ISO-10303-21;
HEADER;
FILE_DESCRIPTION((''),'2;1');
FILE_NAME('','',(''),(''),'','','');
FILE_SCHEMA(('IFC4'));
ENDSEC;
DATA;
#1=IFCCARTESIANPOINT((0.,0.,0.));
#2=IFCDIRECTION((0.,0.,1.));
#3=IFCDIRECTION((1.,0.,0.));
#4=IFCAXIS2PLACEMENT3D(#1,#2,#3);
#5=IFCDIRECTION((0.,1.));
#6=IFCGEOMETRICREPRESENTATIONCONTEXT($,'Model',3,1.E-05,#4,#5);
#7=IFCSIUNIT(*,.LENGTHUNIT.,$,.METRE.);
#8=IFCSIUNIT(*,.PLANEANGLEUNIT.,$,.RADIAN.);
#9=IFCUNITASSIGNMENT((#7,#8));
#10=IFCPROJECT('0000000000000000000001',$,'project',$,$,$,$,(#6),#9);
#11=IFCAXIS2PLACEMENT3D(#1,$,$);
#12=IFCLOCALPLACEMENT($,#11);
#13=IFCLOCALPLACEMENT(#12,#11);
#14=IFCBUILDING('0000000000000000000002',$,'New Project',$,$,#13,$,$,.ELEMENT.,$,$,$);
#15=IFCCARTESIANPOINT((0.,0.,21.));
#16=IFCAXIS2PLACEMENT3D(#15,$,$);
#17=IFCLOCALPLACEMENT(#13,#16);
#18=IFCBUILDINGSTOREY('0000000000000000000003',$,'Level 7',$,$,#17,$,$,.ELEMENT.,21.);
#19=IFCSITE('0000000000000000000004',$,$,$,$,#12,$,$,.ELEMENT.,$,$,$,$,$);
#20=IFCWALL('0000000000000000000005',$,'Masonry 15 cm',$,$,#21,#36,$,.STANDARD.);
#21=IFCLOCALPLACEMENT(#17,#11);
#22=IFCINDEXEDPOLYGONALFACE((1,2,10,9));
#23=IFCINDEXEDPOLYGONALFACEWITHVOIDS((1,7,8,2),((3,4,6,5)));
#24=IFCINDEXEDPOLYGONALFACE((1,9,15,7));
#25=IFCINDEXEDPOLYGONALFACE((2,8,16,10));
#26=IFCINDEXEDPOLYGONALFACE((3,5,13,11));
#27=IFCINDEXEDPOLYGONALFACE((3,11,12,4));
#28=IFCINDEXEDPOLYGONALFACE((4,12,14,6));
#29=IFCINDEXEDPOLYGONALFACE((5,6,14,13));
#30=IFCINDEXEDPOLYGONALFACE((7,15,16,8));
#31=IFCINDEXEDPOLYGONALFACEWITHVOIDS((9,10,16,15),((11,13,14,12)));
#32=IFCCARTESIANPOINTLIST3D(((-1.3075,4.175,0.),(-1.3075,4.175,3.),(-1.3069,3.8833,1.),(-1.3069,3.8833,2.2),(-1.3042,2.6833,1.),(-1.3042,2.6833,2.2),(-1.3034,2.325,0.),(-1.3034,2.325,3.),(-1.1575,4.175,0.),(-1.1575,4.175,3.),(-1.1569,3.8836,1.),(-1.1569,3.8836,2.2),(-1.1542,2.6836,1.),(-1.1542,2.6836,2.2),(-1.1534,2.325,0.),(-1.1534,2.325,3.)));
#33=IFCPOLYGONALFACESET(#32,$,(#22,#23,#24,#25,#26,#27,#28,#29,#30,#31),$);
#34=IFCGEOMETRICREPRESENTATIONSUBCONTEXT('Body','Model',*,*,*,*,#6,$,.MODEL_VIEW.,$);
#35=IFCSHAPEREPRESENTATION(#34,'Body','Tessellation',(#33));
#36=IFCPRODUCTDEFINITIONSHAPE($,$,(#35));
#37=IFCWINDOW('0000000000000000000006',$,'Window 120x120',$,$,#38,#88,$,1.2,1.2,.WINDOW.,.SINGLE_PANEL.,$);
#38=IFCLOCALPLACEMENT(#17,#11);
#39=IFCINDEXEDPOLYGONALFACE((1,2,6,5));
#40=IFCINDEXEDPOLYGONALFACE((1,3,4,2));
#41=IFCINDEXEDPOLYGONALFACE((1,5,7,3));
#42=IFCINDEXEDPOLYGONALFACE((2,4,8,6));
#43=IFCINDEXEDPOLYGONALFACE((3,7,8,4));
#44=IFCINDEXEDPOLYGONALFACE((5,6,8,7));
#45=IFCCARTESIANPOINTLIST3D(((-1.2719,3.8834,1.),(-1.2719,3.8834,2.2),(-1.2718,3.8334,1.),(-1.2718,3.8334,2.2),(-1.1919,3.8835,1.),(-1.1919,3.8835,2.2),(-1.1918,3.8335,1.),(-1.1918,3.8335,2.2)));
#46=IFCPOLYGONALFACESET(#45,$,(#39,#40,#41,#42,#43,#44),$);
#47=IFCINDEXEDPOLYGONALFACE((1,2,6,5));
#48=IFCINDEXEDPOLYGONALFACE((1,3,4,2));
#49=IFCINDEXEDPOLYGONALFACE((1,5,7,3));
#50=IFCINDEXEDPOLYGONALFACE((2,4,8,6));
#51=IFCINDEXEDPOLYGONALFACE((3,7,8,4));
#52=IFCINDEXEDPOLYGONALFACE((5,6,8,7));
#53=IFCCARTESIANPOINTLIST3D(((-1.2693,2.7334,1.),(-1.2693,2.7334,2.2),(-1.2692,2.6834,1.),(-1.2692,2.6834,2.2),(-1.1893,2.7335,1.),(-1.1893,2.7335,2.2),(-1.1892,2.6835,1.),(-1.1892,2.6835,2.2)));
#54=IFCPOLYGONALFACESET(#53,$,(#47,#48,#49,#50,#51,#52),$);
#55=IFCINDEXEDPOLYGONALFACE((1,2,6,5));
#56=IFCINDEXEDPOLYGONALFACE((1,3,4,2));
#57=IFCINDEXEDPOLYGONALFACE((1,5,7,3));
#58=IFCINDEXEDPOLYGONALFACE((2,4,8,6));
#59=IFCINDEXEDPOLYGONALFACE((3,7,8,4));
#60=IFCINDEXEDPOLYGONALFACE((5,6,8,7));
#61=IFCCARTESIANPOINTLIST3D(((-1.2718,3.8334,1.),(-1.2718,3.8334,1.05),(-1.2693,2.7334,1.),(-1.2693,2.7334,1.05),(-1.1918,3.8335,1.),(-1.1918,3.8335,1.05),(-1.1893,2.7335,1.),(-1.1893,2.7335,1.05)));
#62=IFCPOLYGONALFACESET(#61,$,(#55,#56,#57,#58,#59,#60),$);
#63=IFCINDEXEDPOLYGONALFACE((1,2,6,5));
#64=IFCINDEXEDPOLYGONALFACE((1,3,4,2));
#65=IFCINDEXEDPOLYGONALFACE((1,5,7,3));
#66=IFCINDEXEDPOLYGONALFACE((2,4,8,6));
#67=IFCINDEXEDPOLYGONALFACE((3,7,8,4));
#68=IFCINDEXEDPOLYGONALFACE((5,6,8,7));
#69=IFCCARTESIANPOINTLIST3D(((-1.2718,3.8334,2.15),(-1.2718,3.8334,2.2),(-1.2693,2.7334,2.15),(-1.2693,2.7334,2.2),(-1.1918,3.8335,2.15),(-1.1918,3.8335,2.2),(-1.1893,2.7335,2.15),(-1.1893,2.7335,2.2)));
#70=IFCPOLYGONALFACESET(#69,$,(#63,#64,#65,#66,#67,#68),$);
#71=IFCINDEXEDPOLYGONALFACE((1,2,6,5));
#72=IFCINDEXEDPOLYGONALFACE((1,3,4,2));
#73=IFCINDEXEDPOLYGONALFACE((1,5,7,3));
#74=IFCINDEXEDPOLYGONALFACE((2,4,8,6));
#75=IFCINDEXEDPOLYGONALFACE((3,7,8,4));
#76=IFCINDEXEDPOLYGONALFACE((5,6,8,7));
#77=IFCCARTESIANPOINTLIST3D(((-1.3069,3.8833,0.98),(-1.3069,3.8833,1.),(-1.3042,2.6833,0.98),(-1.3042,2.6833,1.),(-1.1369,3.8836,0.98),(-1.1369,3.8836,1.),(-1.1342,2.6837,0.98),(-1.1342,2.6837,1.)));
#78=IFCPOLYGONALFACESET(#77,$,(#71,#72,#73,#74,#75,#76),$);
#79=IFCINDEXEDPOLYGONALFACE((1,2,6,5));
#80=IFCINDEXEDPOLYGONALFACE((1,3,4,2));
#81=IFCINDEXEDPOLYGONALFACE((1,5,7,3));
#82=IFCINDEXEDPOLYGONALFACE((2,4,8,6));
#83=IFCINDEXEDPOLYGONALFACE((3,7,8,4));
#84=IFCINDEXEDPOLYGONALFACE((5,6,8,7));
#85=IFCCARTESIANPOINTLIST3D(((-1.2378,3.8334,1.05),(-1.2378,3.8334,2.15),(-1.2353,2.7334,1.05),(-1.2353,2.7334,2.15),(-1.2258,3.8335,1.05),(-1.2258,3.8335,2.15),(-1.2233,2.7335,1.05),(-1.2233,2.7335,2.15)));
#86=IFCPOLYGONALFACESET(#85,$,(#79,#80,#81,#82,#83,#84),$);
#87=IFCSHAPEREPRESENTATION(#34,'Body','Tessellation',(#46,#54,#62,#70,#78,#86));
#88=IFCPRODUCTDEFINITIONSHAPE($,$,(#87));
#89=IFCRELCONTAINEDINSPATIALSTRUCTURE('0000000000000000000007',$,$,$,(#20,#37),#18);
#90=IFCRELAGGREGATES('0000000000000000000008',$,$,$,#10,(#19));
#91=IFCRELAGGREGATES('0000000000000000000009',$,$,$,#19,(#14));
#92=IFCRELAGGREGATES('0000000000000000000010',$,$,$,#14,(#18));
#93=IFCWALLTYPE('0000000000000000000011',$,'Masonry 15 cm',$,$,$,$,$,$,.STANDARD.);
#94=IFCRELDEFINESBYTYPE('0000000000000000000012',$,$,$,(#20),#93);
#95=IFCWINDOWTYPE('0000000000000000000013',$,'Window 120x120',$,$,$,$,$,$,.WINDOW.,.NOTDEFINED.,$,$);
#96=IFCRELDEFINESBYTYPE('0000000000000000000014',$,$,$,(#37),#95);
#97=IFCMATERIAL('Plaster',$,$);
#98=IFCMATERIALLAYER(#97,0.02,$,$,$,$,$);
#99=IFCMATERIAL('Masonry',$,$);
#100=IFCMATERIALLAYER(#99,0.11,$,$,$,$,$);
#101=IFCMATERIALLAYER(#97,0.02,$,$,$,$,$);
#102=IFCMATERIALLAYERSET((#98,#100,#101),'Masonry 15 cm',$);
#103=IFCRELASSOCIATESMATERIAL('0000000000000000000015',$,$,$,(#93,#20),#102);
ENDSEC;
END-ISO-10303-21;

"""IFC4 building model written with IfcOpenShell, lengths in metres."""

from ifc_helpers import new_model, si_unit, direction, frame, frame_2d, origin, origin_with_axes, place, context, subcontext, project, spatial, polyline, rectangle, outline, extrude, material, layer, layer_set, layer_usage, type_object, element, fill, save


model = new_model("IFC4")

# Units and contexts
model_context = context("Model", 3, precision=1e-05, world=origin_with_axes(), true_north=direction((0.0, 1.0)))
body_context = subcontext(model_context, "Body", "Model", "MODEL_VIEW")
ifc_project = project(units=[si_unit("LENGTHUNIT", "METRE"), si_unit("PLANEANGLEUNIT", "RADIAN")], contexts=[model_context])

# Site, building, storey
site_placement = place(None, origin())
site = spatial("IfcSite", under=ifc_project, at=site_placement, CompositionType="ELEMENT")
building_placement = place(site_placement, origin())
building = spatial("IfcBuilding", under=site, at=building_placement, Name="New Project", CompositionType="ELEMENT")
storey_placement = place(building_placement, frame((0.0, 0.0, 21.0)))
storey = spatial("IfcBuildingStorey", under=building, at=storey_placement, Name="Level 7", CompositionType="ELEMENT", Elevation=21.0)

# Shared definitions
ifc_material_1 = material(Name="Plaster")
ifc_layer_1 = layer(ifc_material_1, 0.02)
ifc_material_2 = material(Name="Masonry")
ifc_layer_2 = layer(ifc_material_2, 0.11)
ifc_layer_3 = layer(ifc_material_1, 0.02)
ifc_layer_set_1 = layer_set([ifc_layer_1, ifc_layer_2, ifc_layer_3], Name="Masonry 15 cm")
ifc_layer_usage_1 = layer_usage(ifc_layer_set_1, "AXIS2", "NEGATIVE", 0.075)
wall_type = type_object("IfcWallType", Name="Masonry 15 cm", PredefinedType="STANDARD", material=ifc_layer_set_1)
window_type = type_object("IfcWindowType", Name="Window 120x120", PartitioningType="NOTDEFINED", PredefinedType="WINDOW")

# Wall, opening, window
wall_1_placement = place(storey_placement, frame((-1.2325, 4.175, 0.0), z_axis=(0.0, 0.0, 1.0), x_axis=(0.002207, -0.999998, 0.0)))
wall_1 = element("IfcWall", 1, at=wall_1_placement, inside=storey, type_object=wall_type, material=ifc_layer_usage_1, Name="Masonry 15 cm", PredefinedType="STANDARD", context=body_context, shape_type="SweptSolid", body=[
    extrude(outline(polyline([(-0.0002, -0.075), (1.8498, -0.075), (1.8502, 0.075), (0.0002, 0.075), (-0.0002, -0.075)])), origin(), (0.0, 0.0, 1.0), 3.0),
])
opening_1_placement = place(wall_1_placement, frame((0.2916, 0.0, 1.0)))
opening_1 = element("IfcOpeningElement", 2, at=opening_1_placement, cuts=wall_1, PredefinedType="OPENING", context=body_context, shape_type="SweptSolid", body=[
    extrude(rectangle(XDim=1.2, YDim=0.25, at=frame_2d((0.6, 0.0))), origin(), (0.0, 0.0, 1.0), 1.2),
])
window_1_placement = place(opening_1_placement, origin())
window_1 = element("IfcWindow", 3, at=window_1_placement, inside=storey, type_object=window_type, Name="Window 120x120", OverallHeight=1.2, OverallWidth=1.2, PartitioningType="SINGLE_PANEL", PredefinedType="WINDOW", context=body_context, shape_type="SweptSolid", body=[
    extrude(outline(polyline([(0.0, -0.04), (0.05, -0.04), (0.05, 0.04), (0.0, 0.04), (0.0, -0.04)])), origin(), (0.0, 0.0, 1.0), 1.2),
    extrude(outline(polyline([(1.15, -0.04), (1.2, -0.04), (1.2, 0.04), (1.15, 0.04), (1.15, -0.04)])), origin(), (0.0, 0.0, 1.0), 1.2),
    extrude(outline(polyline([(0.05, -0.04), (1.15, -0.04), (1.15, 0.04), (0.05, 0.04), (0.05, -0.04)])), origin(), (0.0, 0.0, 1.0), 0.05),
    extrude(outline(polyline([(0.05, -0.04), (1.15, -0.04), (1.15, 0.04), (0.05, 0.04), (0.05, -0.04)])), frame((0.0, 0.0, 1.15)), (0.0, 0.0, 1.0), 0.05),
    extrude(outline(polyline([(0.0, -0.075), (1.2, -0.075), (1.2, 0.095), (0.0, 0.095), (0.0, -0.075)])), frame((0.0, 0.0, -0.02)), (0.0, 0.0, 1.0), 0.02),
    extrude(outline(polyline([(0.05, -0.006), (1.15, -0.006), (1.15, 0.006), (0.05, 0.006), (0.05, -0.006)])), frame((0.0, 0.0, 0.05)), (0.0, 0.0, 1.0), 1.1),
])
fill(opening_1, window_1)

save(model, "model.ifc")
